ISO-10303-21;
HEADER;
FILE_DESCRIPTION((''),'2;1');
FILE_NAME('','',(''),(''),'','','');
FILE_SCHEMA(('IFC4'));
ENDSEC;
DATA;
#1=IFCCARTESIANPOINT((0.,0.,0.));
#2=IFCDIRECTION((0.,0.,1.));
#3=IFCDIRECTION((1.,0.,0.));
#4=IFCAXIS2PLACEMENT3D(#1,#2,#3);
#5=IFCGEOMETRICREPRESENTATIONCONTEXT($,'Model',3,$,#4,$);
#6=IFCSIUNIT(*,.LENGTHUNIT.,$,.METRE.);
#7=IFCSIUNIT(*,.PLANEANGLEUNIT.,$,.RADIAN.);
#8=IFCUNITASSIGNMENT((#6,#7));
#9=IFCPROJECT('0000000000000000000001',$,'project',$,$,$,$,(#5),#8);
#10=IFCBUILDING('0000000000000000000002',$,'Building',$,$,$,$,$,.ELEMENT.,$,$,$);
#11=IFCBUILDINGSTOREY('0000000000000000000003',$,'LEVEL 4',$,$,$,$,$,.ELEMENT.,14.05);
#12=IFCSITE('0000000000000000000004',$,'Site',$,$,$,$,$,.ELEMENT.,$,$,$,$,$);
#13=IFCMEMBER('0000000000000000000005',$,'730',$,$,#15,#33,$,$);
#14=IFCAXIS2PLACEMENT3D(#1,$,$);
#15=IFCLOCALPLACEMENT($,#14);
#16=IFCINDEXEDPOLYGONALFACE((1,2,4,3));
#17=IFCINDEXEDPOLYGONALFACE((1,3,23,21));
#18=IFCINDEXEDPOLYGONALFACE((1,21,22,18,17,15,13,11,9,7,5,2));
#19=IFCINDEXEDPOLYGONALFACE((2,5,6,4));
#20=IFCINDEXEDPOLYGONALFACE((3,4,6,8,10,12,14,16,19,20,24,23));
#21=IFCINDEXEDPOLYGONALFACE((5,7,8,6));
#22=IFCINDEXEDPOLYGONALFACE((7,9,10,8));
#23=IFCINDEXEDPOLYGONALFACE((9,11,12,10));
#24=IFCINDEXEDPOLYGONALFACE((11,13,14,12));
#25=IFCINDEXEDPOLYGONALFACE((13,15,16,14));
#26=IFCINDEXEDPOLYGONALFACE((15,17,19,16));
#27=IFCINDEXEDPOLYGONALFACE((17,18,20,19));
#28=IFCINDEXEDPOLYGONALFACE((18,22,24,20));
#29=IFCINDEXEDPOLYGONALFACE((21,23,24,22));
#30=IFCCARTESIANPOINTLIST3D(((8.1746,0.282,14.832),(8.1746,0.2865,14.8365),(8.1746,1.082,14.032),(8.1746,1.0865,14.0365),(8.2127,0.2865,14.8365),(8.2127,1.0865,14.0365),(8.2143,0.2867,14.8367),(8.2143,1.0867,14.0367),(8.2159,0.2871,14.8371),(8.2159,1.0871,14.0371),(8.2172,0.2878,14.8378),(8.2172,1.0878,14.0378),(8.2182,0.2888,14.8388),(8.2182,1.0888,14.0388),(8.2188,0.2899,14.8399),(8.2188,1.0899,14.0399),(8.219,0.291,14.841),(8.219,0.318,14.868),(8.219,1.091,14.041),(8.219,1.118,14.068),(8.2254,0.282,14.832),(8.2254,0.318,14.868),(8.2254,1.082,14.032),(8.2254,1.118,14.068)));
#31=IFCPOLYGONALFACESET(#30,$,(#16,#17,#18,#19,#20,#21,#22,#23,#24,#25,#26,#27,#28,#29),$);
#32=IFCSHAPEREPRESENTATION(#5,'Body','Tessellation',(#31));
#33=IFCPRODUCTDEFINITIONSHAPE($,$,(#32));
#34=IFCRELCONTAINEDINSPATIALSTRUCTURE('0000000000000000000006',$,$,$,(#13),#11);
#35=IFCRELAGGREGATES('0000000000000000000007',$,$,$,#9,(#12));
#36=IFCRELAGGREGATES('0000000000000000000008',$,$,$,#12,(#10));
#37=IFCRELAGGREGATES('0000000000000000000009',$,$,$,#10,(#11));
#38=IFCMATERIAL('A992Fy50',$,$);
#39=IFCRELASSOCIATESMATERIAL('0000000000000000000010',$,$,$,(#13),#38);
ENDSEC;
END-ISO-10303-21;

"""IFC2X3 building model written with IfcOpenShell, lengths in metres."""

from ifc_helpers import new_model, si_unit, frame, origin_with_axes, origin_2d_with_axis, place, context, project, spatial, l_section, extrude, material, element, save


model = new_model("IFC2X3")

# Units and contexts
model_context = context("Model", 3, world=origin_with_axes())
ifc_project = project(units=[si_unit("LENGTHUNIT", "METRE"), si_unit("PLANEANGLEUNIT", "RADIAN")], contexts=[model_context])

# Site, building, storey
site = spatial("IfcSite", under=ifc_project, Name="Site", CompositionType="ELEMENT")
building = spatial("IfcBuilding", under=site, Name="Building", CompositionType="ELEMENT")
storey = spatial("IfcBuildingStorey", under=building, Name="LEVEL 4", CompositionType="ELEMENT", Elevation=14.05)

# Shared definitions
ifc_material = material(Name="A992Fy50")

# Member
for number, where, z_axis, x_axis, name in (
    (1, (8.2, 0.3, 14.85), (0.0, 0.707107, -0.707107), (-1.0, 0.0, 0.0), "730"),
):
    element("IfcMember", number, at=place(None, frame(where, z_axis=z_axis, x_axis=x_axis)), inside=storey, material=ifc_material, Name=name, context=model_context, shape_type="SweptSolid", body=[
        extrude(l_section(Depth=0.0508, Width=0.0508, Thickness=0.0063, FilletRadius=0.0063, at=origin_2d_with_axis()), origin_with_axes(), (0.0, 0.0, 1.0), 1.1314),
    ])

save(model, "model.ifc")
